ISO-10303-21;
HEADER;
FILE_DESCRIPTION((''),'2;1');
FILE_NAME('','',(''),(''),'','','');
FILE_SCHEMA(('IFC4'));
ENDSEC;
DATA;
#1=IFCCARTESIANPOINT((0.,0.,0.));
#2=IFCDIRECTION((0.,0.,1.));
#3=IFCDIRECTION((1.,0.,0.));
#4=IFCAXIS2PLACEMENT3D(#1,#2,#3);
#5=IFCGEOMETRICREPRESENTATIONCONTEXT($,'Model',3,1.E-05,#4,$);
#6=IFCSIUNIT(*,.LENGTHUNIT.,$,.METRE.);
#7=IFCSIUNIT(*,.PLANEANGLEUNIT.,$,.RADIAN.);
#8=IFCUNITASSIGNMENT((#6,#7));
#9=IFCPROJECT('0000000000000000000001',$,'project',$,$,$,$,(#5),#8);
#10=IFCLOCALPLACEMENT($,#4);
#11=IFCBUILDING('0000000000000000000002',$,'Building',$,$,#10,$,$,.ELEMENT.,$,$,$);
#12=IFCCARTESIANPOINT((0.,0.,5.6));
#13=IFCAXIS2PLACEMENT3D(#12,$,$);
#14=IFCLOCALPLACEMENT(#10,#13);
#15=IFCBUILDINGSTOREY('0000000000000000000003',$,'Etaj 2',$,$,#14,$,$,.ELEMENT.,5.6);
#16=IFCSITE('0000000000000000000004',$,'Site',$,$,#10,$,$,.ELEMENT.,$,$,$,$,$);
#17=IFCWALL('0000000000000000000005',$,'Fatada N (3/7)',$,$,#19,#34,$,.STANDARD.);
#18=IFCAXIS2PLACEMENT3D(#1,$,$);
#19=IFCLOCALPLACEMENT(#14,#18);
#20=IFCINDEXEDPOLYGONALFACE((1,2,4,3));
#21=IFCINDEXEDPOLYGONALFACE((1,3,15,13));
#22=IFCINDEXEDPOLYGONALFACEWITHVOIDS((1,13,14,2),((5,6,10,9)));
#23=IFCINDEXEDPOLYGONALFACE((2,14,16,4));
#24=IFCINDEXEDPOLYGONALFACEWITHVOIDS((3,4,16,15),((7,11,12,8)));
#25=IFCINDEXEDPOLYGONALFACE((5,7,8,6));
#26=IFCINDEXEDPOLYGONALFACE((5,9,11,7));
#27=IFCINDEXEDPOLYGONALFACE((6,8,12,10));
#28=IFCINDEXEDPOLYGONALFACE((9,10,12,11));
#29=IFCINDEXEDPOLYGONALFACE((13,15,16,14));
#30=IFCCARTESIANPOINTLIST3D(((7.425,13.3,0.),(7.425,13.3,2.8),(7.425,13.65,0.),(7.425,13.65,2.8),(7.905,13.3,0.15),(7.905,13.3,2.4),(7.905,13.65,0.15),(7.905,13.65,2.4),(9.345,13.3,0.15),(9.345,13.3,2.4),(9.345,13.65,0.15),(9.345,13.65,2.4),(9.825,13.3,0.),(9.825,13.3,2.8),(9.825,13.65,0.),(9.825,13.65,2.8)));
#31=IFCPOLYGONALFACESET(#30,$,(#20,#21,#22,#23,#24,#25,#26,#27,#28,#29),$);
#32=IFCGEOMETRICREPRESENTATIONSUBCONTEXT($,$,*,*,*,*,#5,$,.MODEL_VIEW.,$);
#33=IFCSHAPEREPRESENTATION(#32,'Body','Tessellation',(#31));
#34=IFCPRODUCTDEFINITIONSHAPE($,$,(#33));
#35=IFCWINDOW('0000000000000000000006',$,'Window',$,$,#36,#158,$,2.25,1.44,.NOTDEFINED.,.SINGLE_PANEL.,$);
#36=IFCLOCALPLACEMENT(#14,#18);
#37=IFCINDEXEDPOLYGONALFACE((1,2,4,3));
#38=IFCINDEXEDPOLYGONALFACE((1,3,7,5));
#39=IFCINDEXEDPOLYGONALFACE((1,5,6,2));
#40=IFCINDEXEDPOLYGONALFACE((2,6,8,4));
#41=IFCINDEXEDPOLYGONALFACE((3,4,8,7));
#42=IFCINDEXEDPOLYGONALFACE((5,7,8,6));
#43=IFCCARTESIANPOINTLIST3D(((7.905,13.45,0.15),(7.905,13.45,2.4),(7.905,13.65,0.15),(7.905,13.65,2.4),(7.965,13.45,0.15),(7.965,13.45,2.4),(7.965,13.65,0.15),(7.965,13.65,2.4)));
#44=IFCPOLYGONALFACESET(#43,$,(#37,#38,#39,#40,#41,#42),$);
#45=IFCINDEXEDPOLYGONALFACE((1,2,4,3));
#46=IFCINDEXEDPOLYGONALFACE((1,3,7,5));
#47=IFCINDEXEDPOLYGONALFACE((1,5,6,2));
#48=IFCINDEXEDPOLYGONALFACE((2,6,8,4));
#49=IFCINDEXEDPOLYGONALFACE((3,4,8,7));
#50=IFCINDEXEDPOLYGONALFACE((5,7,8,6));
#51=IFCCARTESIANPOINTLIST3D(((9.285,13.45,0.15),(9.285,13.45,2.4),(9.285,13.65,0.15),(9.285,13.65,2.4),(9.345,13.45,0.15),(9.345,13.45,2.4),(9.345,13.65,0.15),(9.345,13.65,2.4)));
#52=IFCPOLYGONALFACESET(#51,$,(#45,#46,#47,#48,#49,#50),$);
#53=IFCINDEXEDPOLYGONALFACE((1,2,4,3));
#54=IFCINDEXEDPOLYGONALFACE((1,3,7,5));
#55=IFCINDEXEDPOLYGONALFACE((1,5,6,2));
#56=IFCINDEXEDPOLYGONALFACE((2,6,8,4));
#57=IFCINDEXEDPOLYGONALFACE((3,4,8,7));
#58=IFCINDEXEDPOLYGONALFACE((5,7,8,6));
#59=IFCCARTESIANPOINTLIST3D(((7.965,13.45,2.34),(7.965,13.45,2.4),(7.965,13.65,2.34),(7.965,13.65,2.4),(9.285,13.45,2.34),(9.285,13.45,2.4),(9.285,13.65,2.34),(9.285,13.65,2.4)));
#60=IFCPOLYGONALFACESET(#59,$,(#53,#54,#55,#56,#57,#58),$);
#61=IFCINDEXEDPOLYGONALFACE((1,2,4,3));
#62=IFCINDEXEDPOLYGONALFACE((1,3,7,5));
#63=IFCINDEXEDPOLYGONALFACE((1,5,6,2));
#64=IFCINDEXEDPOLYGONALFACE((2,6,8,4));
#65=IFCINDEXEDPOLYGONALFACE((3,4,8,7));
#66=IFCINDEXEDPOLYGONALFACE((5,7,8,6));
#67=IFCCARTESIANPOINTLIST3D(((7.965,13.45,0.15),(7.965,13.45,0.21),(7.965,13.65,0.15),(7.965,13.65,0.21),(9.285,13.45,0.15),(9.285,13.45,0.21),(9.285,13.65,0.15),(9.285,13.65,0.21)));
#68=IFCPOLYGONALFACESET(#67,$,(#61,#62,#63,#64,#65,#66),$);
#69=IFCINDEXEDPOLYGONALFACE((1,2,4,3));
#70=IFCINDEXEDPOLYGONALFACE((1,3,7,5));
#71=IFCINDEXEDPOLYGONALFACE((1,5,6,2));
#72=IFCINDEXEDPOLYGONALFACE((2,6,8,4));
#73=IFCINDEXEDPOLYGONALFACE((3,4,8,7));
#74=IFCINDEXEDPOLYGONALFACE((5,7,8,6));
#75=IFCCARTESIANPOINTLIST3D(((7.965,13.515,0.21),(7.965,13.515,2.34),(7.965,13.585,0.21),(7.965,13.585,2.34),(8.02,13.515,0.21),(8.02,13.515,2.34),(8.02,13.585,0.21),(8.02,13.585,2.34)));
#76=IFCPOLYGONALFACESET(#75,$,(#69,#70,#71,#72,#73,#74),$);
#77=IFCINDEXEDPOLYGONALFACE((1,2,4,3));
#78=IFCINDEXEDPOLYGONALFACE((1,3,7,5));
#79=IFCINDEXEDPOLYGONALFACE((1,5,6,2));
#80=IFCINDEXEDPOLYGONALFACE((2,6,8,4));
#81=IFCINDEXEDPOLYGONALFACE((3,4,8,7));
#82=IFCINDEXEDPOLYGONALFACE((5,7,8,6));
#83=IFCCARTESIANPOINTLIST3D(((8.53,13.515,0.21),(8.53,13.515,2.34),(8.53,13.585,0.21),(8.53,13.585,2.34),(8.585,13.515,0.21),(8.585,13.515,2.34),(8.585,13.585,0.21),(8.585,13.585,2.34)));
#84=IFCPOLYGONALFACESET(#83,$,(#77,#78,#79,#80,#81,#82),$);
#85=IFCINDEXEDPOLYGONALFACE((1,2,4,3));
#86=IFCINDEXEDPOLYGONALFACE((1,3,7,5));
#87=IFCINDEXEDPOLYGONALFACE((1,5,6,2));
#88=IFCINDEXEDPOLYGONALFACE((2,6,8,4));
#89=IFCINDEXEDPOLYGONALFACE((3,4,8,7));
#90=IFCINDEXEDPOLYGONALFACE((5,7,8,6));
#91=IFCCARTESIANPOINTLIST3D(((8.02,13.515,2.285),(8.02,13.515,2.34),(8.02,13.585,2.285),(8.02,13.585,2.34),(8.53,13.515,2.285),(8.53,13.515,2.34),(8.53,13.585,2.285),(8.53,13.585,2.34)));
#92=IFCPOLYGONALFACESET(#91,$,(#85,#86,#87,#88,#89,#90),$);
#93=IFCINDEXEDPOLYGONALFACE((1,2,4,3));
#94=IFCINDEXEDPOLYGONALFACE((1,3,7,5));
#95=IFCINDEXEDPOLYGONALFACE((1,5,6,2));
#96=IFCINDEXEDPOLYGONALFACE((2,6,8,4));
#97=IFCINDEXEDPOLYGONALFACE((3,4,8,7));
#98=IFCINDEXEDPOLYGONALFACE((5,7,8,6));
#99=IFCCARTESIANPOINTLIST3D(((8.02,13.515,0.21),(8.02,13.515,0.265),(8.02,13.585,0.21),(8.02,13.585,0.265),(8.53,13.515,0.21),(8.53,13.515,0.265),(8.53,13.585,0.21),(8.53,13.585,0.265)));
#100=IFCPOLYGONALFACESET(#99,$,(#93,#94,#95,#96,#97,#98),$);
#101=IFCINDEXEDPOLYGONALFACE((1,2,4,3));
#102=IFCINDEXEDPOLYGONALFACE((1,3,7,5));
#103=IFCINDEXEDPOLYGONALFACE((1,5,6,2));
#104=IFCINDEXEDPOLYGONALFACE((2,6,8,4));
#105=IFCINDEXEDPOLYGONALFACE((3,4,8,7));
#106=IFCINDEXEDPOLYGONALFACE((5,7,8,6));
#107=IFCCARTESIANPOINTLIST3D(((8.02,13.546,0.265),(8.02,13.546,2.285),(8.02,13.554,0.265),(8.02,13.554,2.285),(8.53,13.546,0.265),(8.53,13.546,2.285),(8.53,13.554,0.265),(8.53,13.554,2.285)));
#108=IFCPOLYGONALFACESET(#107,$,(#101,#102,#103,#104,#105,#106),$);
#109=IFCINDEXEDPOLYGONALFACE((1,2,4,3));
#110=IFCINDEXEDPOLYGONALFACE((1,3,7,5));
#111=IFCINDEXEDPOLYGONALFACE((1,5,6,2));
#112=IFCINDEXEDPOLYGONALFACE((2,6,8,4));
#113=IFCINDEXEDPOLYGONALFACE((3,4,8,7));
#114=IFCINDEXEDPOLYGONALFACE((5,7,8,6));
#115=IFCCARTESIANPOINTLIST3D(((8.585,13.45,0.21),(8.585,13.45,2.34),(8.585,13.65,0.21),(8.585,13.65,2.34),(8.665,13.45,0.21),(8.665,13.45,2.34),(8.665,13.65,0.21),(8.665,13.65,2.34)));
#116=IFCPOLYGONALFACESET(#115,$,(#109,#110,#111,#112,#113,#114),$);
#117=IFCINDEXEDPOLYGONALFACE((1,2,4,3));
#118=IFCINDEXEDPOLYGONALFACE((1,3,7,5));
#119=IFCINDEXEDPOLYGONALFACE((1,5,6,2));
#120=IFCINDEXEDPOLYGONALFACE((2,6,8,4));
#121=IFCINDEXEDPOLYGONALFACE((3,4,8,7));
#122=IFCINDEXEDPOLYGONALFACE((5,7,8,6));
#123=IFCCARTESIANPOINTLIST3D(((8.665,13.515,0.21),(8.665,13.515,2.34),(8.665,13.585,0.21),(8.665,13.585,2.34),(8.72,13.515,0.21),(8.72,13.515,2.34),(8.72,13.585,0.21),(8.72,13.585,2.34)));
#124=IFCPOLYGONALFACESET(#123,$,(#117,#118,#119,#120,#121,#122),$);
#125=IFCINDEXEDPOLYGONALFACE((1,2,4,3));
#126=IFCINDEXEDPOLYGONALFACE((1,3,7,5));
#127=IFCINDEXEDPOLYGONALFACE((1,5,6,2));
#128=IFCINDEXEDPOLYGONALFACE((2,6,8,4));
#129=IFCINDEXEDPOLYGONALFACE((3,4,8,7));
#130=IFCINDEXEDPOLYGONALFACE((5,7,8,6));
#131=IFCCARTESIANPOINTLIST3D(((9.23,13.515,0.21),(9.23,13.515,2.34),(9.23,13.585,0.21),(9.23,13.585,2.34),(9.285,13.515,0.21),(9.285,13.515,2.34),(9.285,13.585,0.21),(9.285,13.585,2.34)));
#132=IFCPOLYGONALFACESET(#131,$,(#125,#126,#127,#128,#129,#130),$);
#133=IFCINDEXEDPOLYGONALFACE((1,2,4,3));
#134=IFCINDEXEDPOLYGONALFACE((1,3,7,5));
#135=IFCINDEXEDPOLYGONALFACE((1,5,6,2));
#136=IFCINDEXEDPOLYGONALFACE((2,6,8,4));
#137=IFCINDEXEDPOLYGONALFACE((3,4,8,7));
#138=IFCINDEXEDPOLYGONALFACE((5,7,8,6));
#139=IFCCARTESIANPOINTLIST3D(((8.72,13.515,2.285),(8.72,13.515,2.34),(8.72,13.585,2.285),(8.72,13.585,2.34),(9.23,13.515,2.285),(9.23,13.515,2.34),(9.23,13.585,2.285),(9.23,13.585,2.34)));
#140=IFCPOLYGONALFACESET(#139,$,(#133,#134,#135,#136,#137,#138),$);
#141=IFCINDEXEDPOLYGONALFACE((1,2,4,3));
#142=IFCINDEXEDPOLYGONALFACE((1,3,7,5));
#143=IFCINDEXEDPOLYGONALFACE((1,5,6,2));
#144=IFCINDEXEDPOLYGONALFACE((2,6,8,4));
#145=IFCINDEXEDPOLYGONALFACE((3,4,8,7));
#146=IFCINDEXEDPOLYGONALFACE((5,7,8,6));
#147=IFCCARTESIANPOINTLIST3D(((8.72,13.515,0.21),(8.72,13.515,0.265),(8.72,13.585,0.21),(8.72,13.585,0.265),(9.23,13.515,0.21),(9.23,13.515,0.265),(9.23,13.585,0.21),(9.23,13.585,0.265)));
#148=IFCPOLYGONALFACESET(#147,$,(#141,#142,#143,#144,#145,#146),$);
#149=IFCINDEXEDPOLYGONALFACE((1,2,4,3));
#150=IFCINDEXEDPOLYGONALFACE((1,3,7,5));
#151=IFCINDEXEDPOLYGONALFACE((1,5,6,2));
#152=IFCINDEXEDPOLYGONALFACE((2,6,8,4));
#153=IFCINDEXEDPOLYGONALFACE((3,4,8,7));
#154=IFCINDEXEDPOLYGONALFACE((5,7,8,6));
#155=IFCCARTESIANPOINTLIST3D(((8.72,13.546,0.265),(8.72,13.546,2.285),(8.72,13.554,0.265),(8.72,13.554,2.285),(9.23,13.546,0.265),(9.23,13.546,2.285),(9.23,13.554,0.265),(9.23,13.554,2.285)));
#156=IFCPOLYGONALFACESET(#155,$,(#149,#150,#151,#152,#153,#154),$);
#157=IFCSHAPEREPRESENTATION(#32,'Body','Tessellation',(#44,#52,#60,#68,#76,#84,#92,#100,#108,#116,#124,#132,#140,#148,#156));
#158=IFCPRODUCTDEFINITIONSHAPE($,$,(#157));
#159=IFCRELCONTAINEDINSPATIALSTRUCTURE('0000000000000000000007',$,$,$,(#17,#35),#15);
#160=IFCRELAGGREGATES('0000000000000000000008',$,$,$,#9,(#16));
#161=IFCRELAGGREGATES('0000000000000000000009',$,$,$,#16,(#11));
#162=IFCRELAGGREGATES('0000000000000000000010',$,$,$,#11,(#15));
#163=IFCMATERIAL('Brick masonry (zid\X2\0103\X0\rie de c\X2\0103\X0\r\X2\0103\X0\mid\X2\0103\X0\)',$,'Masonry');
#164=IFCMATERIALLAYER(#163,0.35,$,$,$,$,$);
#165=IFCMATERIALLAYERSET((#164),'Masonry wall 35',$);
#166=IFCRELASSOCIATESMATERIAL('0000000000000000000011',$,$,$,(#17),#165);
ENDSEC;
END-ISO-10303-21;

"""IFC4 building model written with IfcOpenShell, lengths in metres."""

from ifc_helpers import new_model, si_unit, frame, frame_2d, origin, origin_with_axes, origin_2d, place, context, subcontext, project, spatial, rectangle, extrude, material, layer, layer_set, layer_usage, element, fill, save


model = new_model("IFC4")

# Units and contexts
model_context = context("Model", 3, precision=1e-05, world=origin_with_axes())
sub_context = subcontext(model_context, None, None, "MODEL_VIEW")
ifc_project = project(units=[si_unit("LENGTHUNIT", "METRE"), si_unit("PLANEANGLEUNIT", "RADIAN")], contexts=[model_context])

# Site, building, storey
placement = place(None, origin_with_axes())
site = spatial("IfcSite", under=ifc_project, at=placement, Name="Site", CompositionType="ELEMENT")
building = spatial("IfcBuilding", under=site, at=placement, Name="Building", CompositionType="ELEMENT")
storey_placement = place(placement, frame((0.0, 0.0, 5.6)))
storey = spatial("IfcBuildingStorey", under=building, at=storey_placement, Name="Etaj 2", CompositionType="ELEMENT", Elevation=5.6)

# Wall, opening, window
ifc_material_1 = material(Name="Brick masonry (zidărie de cărămidă)", Category="Masonry")
ifc_layer_1 = layer(ifc_material_1, 0.35)
ifc_layer_set_1 = layer_set([ifc_layer_1], Name="Masonry wall 35")
ifc_layer_usage_1 = layer_usage(ifc_layer_set_1, "AXIS2", "POSITIVE", -0.175)
wall_1_placement = place(storey_placement, frame((7.425, 13.475, 0.0), x_axis=(1.0, 0.0, 0.0)))
wall_1 = element("IfcWall", 1, at=wall_1_placement, inside=storey, material=ifc_layer_usage_1, Name="Fatada N (3/7)", PredefinedType="STANDARD", context=sub_context, shape_type="SweptSolid", body=[
    extrude(rectangle(XDim=2.4, YDim=0.35, at=frame_2d((1.2, 0.0))), origin(), (0.0, 0.0, 1.0), 2.8),
])
opening_1_placement = place(wall_1_placement, frame((1.2, 0.225, 0.15), z_axis=(0.0, -1.0, 0.0), x_axis=(1.0, 0.0, 0.0)))
opening_1 = element("IfcOpeningElement", 2, at=opening_1_placement, cuts=wall_1, PredefinedType="OPENING", context=sub_context, shape_type="SweptSolid", body=[
    extrude(rectangle(XDim=1.44, YDim=2.25, at=frame_2d((0.0, 1.125))), origin(), (0.0, 0.0, 1.0), 0.45),
])
window_1_placement = place(wall_1_placement, frame((1.2, 0.175, 0.15), z_axis=(0.0, -1.0, 0.0), x_axis=(1.0, 0.0, 0.0)))
window_1 = element("IfcWindow", 3, at=window_1_placement, inside=storey, Name="Window", OverallHeight=2.25, OverallWidth=1.44, PartitioningType="SINGLE_PANEL", PredefinedType="NOTDEFINED", context=sub_context, shape_type="SweptSolid", body=[
    extrude(rectangle(XDim=0.06, YDim=2.25, at=origin_2d()), frame((-0.69, 1.125, 0.0)), (0.0, 0.0, 1.0), 0.2),
    extrude(rectangle(XDim=0.06, YDim=2.25, at=origin_2d()), frame((0.69, 1.125, 0.0)), (0.0, 0.0, 1.0), 0.2),
    extrude(rectangle(XDim=1.32, YDim=0.06, at=origin_2d()), frame((0.0, 2.22, 0.0)), (0.0, 0.0, 1.0), 0.2),
    extrude(rectangle(XDim=1.32, YDim=0.06, at=origin_2d()), frame((0.0, 0.03, 0.0)), (0.0, 0.0, 1.0), 0.2),
    extrude(rectangle(XDim=0.055, YDim=2.13, at=origin_2d()), frame((-0.6325, 1.125, 0.065)), (0.0, 0.0, 1.0), 0.07),
    extrude(rectangle(XDim=0.055, YDim=2.13, at=origin_2d()), frame((-0.0675, 1.125, 0.065)), (0.0, 0.0, 1.0), 0.07),
    extrude(rectangle(XDim=0.51, YDim=0.055, at=origin_2d()), frame((-0.35, 2.1625, 0.065)), (0.0, 0.0, 1.0), 0.07),
    extrude(rectangle(XDim=0.51, YDim=0.055, at=origin_2d()), frame((-0.35, 0.0875, 0.065)), (0.0, 0.0, 1.0), 0.07),
    extrude(rectangle(XDim=0.51, YDim=2.02, at=origin_2d()), frame((-0.35, 1.125, 0.096)), (0.0, 0.0, 1.0), 0.008),
    extrude(rectangle(XDim=0.08, YDim=2.13, at=origin_2d()), frame((0.0, 1.125, 0.0)), (0.0, 0.0, 1.0), 0.2),
    extrude(rectangle(XDim=0.055, YDim=2.13, at=origin_2d()), frame((0.0675, 1.125, 0.065)), (0.0, 0.0, 1.0), 0.07),
    extrude(rectangle(XDim=0.055, YDim=2.13, at=origin_2d()), frame((0.6325, 1.125, 0.065)), (0.0, 0.0, 1.0), 0.07),
    extrude(rectangle(XDim=0.51, YDim=0.055, at=origin_2d()), frame((0.35, 2.1625, 0.065)), (0.0, 0.0, 1.0), 0.07),
    extrude(rectangle(XDim=0.51, YDim=0.055, at=origin_2d()), frame((0.35, 0.0875, 0.065)), (0.0, 0.0, 1.0), 0.07),
    extrude(rectangle(XDim=0.51, YDim=2.02, at=origin_2d()), frame((0.35, 1.125, 0.096)), (0.0, 0.0, 1.0), 0.008),
])
fill(opening_1, window_1)

save(model, "model.ifc")
